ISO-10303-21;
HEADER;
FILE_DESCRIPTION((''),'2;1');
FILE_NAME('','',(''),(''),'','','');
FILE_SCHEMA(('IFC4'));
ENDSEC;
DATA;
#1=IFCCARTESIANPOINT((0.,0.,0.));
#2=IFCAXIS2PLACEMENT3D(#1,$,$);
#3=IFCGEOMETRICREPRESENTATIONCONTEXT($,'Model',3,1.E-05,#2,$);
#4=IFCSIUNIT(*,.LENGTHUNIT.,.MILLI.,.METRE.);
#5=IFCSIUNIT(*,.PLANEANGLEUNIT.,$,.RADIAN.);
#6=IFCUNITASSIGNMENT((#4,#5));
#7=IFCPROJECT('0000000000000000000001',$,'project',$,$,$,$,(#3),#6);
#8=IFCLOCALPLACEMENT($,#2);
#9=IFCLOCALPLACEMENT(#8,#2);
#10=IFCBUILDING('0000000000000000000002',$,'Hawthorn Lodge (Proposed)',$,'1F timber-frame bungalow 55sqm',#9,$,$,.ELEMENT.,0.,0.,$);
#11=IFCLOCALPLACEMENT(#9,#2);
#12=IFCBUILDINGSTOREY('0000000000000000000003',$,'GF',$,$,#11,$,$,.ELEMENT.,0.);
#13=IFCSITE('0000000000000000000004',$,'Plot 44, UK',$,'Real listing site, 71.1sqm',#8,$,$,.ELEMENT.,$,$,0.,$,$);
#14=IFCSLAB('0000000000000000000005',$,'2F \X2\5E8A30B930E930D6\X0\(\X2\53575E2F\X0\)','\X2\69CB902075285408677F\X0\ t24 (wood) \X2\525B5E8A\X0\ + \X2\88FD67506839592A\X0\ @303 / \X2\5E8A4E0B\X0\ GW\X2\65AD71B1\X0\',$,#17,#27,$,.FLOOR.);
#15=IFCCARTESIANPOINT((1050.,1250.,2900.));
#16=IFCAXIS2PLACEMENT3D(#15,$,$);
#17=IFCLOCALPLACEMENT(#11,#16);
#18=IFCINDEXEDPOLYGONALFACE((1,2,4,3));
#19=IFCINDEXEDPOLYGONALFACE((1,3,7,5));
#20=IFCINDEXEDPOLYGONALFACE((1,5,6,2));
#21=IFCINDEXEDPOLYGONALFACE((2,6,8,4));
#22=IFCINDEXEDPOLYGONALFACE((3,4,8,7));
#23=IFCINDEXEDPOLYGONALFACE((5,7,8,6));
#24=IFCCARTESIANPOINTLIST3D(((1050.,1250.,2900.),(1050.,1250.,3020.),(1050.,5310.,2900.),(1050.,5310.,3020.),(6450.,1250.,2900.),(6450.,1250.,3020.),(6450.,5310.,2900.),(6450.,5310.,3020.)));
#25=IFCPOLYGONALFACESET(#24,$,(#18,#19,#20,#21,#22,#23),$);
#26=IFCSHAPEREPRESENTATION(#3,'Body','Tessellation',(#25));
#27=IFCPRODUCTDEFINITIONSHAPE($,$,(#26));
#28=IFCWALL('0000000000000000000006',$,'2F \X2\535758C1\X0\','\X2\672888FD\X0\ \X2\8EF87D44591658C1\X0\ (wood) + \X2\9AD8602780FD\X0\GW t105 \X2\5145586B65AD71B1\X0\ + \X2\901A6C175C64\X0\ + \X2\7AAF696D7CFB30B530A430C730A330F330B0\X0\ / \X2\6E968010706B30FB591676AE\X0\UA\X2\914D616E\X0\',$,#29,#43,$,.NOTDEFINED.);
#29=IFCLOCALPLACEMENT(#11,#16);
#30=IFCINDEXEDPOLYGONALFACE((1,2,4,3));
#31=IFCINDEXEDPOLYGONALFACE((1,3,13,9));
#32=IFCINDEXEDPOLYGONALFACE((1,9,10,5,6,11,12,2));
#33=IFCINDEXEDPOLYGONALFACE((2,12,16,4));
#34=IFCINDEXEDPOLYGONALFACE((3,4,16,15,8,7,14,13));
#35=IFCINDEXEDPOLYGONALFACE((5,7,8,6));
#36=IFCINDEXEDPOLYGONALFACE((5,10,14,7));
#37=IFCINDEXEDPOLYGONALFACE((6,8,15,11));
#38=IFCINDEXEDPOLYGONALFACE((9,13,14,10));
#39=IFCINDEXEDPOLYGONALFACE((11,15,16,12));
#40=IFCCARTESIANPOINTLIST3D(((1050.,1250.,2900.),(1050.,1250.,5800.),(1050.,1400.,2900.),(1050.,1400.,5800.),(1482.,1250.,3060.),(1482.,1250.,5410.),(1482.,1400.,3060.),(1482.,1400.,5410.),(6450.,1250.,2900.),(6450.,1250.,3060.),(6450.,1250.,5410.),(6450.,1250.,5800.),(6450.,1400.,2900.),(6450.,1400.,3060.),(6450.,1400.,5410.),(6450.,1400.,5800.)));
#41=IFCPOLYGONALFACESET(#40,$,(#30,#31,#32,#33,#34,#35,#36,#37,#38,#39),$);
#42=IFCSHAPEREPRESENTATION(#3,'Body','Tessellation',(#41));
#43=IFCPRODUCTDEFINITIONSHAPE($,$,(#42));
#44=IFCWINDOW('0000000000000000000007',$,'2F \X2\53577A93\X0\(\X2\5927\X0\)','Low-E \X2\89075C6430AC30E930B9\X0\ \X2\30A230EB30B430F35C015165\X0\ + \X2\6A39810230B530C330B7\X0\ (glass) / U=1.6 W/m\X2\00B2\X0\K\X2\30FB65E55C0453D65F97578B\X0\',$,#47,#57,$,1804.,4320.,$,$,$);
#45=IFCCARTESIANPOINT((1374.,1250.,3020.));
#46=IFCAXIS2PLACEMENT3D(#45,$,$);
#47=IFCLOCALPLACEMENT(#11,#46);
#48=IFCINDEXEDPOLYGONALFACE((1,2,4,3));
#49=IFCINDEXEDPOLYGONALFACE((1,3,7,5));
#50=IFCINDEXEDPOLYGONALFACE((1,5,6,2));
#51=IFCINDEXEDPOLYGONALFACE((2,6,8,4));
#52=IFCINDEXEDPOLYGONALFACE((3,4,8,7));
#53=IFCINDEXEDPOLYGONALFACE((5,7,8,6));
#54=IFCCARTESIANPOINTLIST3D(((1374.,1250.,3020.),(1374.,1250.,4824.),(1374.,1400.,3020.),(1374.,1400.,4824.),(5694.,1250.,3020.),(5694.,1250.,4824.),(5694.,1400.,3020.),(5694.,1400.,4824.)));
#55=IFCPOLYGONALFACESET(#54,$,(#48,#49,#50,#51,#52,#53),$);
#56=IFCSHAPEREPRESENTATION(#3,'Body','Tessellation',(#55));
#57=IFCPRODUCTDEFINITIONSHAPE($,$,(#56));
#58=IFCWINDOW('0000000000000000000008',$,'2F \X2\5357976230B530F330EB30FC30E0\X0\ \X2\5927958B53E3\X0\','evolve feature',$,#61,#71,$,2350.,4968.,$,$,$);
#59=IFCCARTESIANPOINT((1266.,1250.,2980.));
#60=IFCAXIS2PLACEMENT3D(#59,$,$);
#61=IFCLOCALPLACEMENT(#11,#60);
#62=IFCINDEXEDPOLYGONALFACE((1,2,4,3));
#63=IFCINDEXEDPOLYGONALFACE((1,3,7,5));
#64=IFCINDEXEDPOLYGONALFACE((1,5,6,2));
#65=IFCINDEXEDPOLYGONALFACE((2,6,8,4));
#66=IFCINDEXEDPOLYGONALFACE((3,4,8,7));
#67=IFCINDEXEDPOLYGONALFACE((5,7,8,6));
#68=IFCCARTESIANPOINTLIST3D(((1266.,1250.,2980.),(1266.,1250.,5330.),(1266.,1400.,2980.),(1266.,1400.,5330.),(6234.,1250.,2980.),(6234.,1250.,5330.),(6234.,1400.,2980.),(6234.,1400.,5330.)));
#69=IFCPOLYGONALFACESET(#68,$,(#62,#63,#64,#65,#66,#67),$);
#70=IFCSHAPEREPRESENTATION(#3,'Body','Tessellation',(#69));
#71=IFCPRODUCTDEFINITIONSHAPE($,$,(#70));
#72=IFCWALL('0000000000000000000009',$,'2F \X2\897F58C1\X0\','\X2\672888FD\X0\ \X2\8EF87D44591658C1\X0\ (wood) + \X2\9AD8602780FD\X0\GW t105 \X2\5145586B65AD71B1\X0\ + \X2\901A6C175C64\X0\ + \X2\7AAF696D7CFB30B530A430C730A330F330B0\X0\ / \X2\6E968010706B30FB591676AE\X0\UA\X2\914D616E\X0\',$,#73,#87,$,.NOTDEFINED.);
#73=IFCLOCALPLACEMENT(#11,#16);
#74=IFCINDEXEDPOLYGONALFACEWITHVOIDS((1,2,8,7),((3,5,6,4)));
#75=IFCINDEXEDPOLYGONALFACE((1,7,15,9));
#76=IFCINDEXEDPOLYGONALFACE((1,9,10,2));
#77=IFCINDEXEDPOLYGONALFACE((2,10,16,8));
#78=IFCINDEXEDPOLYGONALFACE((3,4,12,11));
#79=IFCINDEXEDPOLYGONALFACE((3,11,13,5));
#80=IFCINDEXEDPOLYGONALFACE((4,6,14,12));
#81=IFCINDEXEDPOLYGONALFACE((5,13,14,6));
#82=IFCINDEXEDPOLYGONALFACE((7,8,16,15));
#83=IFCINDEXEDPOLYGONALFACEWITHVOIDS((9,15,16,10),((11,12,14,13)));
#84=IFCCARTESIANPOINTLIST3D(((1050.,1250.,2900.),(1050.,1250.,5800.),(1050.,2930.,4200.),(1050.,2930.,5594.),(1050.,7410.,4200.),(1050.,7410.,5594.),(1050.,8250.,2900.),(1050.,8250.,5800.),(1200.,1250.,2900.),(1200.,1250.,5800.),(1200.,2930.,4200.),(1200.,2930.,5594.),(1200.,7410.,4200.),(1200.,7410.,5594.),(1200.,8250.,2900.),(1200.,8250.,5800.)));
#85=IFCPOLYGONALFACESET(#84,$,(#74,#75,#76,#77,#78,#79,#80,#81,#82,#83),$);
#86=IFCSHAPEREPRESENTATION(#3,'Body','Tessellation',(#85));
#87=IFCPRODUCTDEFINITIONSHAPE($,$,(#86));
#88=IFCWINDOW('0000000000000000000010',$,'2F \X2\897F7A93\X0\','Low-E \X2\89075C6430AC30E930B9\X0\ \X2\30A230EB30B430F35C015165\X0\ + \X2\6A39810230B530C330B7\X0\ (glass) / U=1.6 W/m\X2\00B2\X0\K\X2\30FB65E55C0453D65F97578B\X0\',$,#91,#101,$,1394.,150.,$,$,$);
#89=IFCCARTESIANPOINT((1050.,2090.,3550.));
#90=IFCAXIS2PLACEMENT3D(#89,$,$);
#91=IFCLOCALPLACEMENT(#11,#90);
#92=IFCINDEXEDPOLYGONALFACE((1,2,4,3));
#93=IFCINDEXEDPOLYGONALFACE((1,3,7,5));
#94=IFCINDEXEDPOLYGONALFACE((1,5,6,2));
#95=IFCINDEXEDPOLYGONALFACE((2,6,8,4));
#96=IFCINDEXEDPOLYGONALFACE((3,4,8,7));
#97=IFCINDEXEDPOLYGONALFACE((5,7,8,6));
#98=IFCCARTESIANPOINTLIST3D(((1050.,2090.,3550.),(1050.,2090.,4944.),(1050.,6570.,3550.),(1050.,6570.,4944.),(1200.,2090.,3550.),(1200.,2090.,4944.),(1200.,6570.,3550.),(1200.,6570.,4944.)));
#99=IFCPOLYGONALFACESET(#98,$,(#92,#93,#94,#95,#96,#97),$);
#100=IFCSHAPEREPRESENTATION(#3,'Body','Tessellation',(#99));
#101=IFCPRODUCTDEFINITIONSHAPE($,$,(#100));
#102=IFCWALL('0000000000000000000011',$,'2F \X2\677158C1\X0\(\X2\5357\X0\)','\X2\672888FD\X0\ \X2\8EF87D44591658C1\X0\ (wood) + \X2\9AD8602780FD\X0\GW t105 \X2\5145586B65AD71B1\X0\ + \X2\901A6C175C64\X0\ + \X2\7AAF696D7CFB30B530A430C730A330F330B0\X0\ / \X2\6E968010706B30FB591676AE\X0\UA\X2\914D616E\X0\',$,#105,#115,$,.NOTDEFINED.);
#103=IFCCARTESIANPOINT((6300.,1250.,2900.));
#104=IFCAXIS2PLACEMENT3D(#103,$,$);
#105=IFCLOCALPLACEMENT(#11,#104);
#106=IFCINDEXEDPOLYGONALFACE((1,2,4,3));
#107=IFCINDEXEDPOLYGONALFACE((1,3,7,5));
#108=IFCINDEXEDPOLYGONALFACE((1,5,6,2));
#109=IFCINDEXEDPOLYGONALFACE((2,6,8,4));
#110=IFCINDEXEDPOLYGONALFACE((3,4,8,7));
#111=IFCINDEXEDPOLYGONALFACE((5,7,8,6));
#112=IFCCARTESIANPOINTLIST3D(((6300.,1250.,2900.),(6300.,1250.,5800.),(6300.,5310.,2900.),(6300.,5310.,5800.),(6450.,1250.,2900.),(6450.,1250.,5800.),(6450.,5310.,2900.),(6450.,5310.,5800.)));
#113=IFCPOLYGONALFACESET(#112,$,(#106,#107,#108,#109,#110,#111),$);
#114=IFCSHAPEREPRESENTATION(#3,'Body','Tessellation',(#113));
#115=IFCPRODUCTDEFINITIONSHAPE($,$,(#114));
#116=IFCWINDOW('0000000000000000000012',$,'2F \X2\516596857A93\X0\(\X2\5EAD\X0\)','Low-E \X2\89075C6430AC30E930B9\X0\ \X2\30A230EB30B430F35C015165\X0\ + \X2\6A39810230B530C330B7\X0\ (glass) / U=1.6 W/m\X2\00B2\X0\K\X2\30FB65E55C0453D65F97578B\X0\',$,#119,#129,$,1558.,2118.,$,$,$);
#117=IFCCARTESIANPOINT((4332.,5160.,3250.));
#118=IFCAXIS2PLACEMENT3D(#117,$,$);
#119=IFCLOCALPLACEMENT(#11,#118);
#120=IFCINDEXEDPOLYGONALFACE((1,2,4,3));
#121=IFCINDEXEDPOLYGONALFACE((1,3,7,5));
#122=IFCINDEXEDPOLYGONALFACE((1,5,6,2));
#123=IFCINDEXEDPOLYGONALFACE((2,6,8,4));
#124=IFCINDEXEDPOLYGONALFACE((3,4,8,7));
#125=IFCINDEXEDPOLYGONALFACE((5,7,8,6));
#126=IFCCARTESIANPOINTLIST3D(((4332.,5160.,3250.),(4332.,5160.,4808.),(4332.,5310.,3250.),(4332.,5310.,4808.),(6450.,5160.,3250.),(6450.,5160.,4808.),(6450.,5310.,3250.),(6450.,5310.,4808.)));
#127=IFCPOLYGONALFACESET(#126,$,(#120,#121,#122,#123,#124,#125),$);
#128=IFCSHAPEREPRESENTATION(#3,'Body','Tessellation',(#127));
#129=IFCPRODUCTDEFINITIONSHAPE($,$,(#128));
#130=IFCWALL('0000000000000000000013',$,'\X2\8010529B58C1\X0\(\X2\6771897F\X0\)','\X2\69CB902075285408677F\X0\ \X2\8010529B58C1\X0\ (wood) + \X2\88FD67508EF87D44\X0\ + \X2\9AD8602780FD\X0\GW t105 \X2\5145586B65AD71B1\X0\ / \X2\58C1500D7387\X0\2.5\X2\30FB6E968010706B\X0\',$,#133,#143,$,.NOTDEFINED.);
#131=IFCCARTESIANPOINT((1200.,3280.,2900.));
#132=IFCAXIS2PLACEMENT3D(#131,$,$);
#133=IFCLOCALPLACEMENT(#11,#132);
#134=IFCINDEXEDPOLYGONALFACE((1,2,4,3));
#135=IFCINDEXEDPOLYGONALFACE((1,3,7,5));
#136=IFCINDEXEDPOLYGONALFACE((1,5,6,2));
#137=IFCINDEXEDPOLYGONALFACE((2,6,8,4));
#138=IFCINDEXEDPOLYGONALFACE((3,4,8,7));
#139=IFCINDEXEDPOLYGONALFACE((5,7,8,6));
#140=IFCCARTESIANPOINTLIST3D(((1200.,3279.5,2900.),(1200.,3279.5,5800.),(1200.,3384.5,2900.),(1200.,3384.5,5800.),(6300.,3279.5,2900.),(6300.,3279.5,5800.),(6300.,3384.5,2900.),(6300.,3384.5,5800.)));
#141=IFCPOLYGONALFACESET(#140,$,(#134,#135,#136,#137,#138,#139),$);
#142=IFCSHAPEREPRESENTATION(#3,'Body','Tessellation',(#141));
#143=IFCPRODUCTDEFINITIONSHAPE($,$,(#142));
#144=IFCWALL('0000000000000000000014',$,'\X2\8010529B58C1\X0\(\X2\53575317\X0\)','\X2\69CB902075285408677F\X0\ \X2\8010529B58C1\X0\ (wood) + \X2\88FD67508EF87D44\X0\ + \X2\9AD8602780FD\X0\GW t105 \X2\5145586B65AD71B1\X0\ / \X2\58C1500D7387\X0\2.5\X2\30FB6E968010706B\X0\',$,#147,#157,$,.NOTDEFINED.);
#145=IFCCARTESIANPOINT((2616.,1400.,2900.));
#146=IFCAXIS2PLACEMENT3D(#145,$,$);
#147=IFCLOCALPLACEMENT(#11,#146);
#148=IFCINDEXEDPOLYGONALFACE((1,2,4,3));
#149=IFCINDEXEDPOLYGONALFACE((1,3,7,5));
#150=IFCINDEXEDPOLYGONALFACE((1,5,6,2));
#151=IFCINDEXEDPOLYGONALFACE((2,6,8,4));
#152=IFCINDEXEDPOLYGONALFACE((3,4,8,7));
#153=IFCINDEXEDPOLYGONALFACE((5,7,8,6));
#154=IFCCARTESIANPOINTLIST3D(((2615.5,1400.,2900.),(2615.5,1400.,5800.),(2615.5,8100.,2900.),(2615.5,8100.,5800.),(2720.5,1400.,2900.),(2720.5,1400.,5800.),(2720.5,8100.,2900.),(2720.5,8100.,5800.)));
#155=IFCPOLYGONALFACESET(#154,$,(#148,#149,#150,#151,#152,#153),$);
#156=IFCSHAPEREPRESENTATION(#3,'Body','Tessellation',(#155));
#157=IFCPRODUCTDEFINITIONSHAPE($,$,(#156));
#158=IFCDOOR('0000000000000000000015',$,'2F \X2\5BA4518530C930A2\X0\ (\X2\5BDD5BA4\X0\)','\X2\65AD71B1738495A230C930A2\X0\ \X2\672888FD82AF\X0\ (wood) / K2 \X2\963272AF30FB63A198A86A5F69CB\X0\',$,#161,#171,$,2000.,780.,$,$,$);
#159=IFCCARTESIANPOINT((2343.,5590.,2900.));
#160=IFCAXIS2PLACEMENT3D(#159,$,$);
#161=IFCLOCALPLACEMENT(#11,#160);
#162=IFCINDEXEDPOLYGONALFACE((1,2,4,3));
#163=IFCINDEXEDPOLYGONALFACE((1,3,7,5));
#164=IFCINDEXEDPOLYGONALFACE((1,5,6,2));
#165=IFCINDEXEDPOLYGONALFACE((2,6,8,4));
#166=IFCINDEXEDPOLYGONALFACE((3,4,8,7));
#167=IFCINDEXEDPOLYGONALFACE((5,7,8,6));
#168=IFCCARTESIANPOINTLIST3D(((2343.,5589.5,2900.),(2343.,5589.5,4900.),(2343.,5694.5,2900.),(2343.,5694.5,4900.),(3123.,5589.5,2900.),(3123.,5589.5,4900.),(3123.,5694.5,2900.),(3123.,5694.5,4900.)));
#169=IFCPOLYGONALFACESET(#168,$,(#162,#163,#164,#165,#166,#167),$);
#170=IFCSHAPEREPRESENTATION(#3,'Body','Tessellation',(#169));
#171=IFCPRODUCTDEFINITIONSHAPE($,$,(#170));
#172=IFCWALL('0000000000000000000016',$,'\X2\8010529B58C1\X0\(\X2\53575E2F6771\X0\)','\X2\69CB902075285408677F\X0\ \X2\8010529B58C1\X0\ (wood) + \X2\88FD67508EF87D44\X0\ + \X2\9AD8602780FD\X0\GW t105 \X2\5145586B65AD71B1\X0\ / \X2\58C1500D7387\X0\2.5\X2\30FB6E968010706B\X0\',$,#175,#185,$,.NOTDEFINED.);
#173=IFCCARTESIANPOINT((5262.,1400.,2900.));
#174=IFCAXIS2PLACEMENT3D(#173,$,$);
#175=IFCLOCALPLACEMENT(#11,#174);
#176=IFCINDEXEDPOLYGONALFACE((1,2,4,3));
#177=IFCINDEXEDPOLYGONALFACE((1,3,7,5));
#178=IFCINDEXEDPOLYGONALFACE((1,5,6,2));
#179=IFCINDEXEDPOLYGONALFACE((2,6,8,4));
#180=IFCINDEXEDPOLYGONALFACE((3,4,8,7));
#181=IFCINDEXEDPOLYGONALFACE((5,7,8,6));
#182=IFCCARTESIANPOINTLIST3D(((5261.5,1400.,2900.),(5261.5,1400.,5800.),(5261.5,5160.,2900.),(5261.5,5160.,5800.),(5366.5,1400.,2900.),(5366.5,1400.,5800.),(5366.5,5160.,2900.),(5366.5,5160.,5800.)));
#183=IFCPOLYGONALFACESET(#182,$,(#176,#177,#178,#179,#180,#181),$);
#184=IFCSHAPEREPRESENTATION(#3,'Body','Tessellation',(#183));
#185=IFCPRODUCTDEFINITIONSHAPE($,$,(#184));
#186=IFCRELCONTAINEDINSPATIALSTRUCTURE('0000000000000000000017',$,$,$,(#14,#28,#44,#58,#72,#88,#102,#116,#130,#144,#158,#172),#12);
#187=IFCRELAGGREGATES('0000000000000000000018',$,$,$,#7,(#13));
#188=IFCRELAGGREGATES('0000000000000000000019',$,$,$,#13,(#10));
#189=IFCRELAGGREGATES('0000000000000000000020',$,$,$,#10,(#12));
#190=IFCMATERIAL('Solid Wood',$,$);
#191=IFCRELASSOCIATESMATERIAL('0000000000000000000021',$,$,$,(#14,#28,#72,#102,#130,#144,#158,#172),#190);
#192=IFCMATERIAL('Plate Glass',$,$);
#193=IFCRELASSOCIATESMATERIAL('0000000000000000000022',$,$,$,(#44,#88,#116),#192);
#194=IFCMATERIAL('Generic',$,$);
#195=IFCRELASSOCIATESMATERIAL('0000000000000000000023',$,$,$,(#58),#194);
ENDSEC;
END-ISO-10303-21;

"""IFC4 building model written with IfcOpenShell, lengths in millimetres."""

from ifc_helpers import new_model, si_unit, frame, frame_2d, origin, place, context, project, spatial, rectangle, extrude, material, element, fill, save


model = new_model("IFC4")

# Units and contexts
model_context = context("Model", 3, precision=1e-05, world=origin())
ifc_project = project(units=[si_unit("LENGTHUNIT", "METRE", prefix="MILLI"), si_unit("PLANEANGLEUNIT", "RADIAN")], contexts=[model_context])

# Site, building, storey
site_placement = place(None, origin())
site = spatial("IfcSite", under=ifc_project, at=site_placement, Name="Plot 44, UK", ObjectType="Real listing site, 71.1sqm", CompositionType="ELEMENT", RefElevation=0.0)
building_placement = place(site_placement, origin())
building = spatial("IfcBuilding", under=site, at=building_placement, Name="Hawthorn Lodge (Proposed)", ObjectType="1F timber-frame bungalow 55sqm", CompositionType="ELEMENT", ElevationOfRefHeight=0.0, ElevationOfTerrain=0.0)
storey_placement = place(building_placement, origin())
storey = spatial("IfcBuildingStorey", under=building, at=storey_placement, Name="GF", CompositionType="ELEMENT", Elevation=0.0)

# Slab
ifc_material_1 = material(Name="Solid Wood")
slab_placement = place(storey_placement, frame((1050.0, 1250.0, 2900.0)))
element("IfcSlab", 1, at=slab_placement, inside=storey, material=ifc_material_1, Name="2F 床スラブ(南帯)", Description="構造用合板 t24 (wood) 剛床 + 製材根太 @303 / 床下 GW断熱", PredefinedType="FLOOR", context=model_context, shape_type="SweptSolid", body=[
    extrude(rectangle(XDim=5400.0, YDim=4060.0, at=frame_2d((2700.0, 2030.0))), frame((1050.0, 1250.0, 2900.0)), (0.0, 0.0, 1.0), 120.0),
])

# Wall, openings, windows
wall_1_placement = place(storey_placement, frame((1050.0, 1250.0, 2900.0)))
wall_1 = element("IfcWall", 2, at=wall_1_placement, inside=storey, material=ifc_material_1, Name="2F 南壁", Description="木製 軸組外壁 (wood) + 高性能GW t105 充填断熱 + 通気層 + 窯業系サイディング / 準耐火・外皮UA配慮", PredefinedType="NOTDEFINED", context=model_context, shape_type="SweptSolid", body=[
    extrude(rectangle(XDim=5400.0, YDim=150.0, at=frame_2d((2700.0, 75.0))), frame((1050.0, 1250.0, 2900.0)), (0.0, 0.0, 1.0), 2900.0),
])
opening_1_placement = place(storey_placement, frame((1374.0, 1250.0, 3020.0)))
opening_1 = element("IfcOpeningElement", 3, at=opening_1_placement, cuts=wall_1, PredefinedType="NOTDEFINED", context=model_context, shape_type="SweptSolid", body=[
    extrude(rectangle(XDim=4320.0, YDim=150.0, at=frame_2d((2160.0, 75.0))), frame((1374.0, 1250.0, 3020.0)), (0.0, 0.0, 1.0), 1804.0),
])
opening_2_placement = place(storey_placement, frame((1266.0, 1250.0, 2980.0)))
opening_2 = element("IfcOpeningElement", 4, at=opening_2_placement, cuts=wall_1, PredefinedType="NOTDEFINED", context=model_context, shape_type="SweptSolid", body=[
    extrude(rectangle(XDim=4968.0, YDim=150.0, at=frame_2d((2484.0, 75.0))), frame((1266.0, 1250.0, 2980.0)), (0.0, 0.0, 1.0), 2350.0),
])
ifc_material_2 = material(Name="Plate Glass")
window_1_placement = place(storey_placement, frame((1374.0, 1250.0, 3020.0)))
window_1 = element("IfcWindow", 5, at=window_1_placement, inside=storey, material=ifc_material_2, Name="2F 南窓(大)", Description="Low-E 複層ガラス アルゴン封入 + 樹脂サッシ (glass) / U=1.6 W/m²K・日射取得型", OverallHeight=1804.0, OverallWidth=4320.0, context=model_context, shape_type="SweptSolid", body=[
    extrude(rectangle(XDim=4320.0, YDim=150.0, at=frame_2d((2160.0, 75.0))), frame((1374.0, 1250.0, 3020.0)), (0.0, 0.0, 1.0), 1804.0),
])
fill(opening_1, window_1)
ifc_material_3 = material(Name="Generic")
window_2_placement = place(storey_placement, frame((1266.0, 1250.0, 2980.0)))
window_2 = element("IfcWindow", 6, at=window_2_placement, inside=storey, material=ifc_material_3, Name="2F 南面サンルーム 大開口", Description="evolve feature", OverallHeight=2350.0, OverallWidth=4968.0, context=model_context, shape_type="SweptSolid", body=[
    extrude(rectangle(XDim=4968.0, YDim=150.0, at=frame_2d((2484.0, 75.0))), frame((1266.0, 1250.0, 2980.0)), (0.0, 0.0, 1.0), 2350.0),
])
fill(opening_2, window_2)

# Walls, openings, windows
wall_2_placement = place(storey_placement, frame((1050.0, 1250.0, 2900.0)))
wall_2 = element("IfcWall", 7, at=wall_2_placement, inside=storey, material=ifc_material_1, Name="2F 西壁", Description="木製 軸組外壁 (wood) + 高性能GW t105 充填断熱 + 通気層 + 窯業系サイディング / 準耐火・外皮UA配慮", PredefinedType="NOTDEFINED", context=model_context, shape_type="SweptSolid", body=[
    extrude(rectangle(XDim=150.0, YDim=7000.0, at=frame_2d((75.0, 3500.0))), frame((1050.0, 1250.0, 2900.0)), (0.0, 0.0, 1.0), 2900.0),
])
opening_3_placement = place(storey_placement, frame((1050.0, 2090.0, 3550.0)))
opening_3 = element("IfcOpeningElement", 8, at=opening_3_placement, cuts=wall_2, PredefinedType="NOTDEFINED", context=model_context, shape_type="SweptSolid", body=[
    extrude(rectangle(XDim=150.0, YDim=4480.0, at=frame_2d((75.0, 2240.0))), frame((1050.0, 2090.0, 3550.0)), (0.0, 0.0, 1.0), 1394.0),
])
window_3_placement = place(storey_placement, frame((1050.0, 2090.0, 3550.0)))
window_3 = element("IfcWindow", 9, at=window_3_placement, inside=storey, material=ifc_material_2, Name="2F 西窓", Description="Low-E 複層ガラス アルゴン封入 + 樹脂サッシ (glass) / U=1.6 W/m²K・日射取得型", OverallHeight=1394.0, OverallWidth=150.0, context=model_context, shape_type="SweptSolid", body=[
    extrude(rectangle(XDim=150.0, YDim=4480.0, at=frame_2d((75.0, 2240.0))), frame((1050.0, 2090.0, 3550.0)), (0.0, 0.0, 1.0), 1394.0),
])
fill(opening_3, window_3)
wall_3_placement = place(storey_placement, frame((6300.0, 1250.0, 2900.0)))
wall_3 = element("IfcWall", 10, at=wall_3_placement, inside=storey, material=ifc_material_1, Name="2F 東壁(南)", Description="木製 軸組外壁 (wood) + 高性能GW t105 充填断熱 + 通気層 + 窯業系サイディング / 準耐火・外皮UA配慮", PredefinedType="NOTDEFINED", context=model_context, shape_type="SweptSolid", body=[
    extrude(rectangle(XDim=150.0, YDim=4060.0, at=frame_2d((75.0, 2030.0))), frame((6300.0, 1250.0, 2900.0)), (0.0, 0.0, 1.0), 2900.0),
])
opening_4_placement = place(storey_placement, frame((4332.0, 5160.0, 3250.0)))
opening_4 = element("IfcOpeningElement", 11, at=opening_4_placement, cuts=wall_3, PredefinedType="NOTDEFINED", context=model_context, shape_type="SweptSolid", body=[
    extrude(rectangle(XDim=2118.0, YDim=150.0, at=frame_2d((1059.0, 75.0))), frame((4332.0, 5160.0, 3250.0)), (0.0, 0.0, 1.0), 1558.0),
])
window_4_placement = place(storey_placement, frame((4332.0, 5160.0, 3250.0)))
window_4 = element("IfcWindow", 12, at=window_4_placement, inside=storey, material=ifc_material_2, Name="2F 入隅窓(庭)", Description="Low-E 複層ガラス アルゴン封入 + 樹脂サッシ (glass) / U=1.6 W/m²K・日射取得型", OverallHeight=1558.0, OverallWidth=2118.0, context=model_context, shape_type="SweptSolid", body=[
    extrude(rectangle(XDim=2118.0, YDim=150.0, at=frame_2d((1059.0, 75.0))), frame((4332.0, 5160.0, 3250.0)), (0.0, 0.0, 1.0), 1558.0),
])
fill(opening_4, window_4)

# Wall
wall_4_placement = place(storey_placement, frame((1200.0, 3280.0, 2900.0)))
element("IfcWall", 13, at=wall_4_placement, inside=storey, material=ifc_material_1, Name="耐力壁(東西)", Description="構造用合板 耐力壁 (wood) + 製材軸組 + 高性能GW t105 充填断熱 / 壁倍率2.5・準耐火", PredefinedType="NOTDEFINED", context=model_context, shape_type="SweptSolid", body=[
    extrude(rectangle(XDim=5100.0, YDim=105.0, at=frame_2d((2550.0, 52.0))), frame((1200.0, 3280.0, 2900.0)), (0.0, 0.0, 1.0), 2900.0),
])

# Wall, opening, door
wall_5_placement = place(storey_placement, frame((2616.0, 1400.0, 2900.0)))
wall_5 = element("IfcWall", 14, at=wall_5_placement, inside=storey, material=ifc_material_1, Name="耐力壁(南北)", Description="構造用合板 耐力壁 (wood) + 製材軸組 + 高性能GW t105 充填断熱 / 壁倍率2.5・準耐火", PredefinedType="NOTDEFINED", context=model_context, shape_type="SweptSolid", body=[
    extrude(rectangle(XDim=105.0, YDim=6700.0, at=frame_2d((52.0, 3350.0))), frame((2616.0, 1400.0, 2900.0)), (0.0, 0.0, 1.0), 2900.0),
])
opening_5_placement = place(storey_placement, frame((2343.0, 5590.0, 2900.0)))
opening_5 = element("IfcOpeningElement", 15, at=opening_5_placement, cuts=wall_5, PredefinedType="NOTDEFINED", context=model_context, shape_type="SweptSolid", body=[
    extrude(rectangle(XDim=780.0, YDim=105.0, at=frame_2d((390.0, 52.0))), frame((2343.0, 5590.0, 2900.0)), (0.0, 0.0, 1.0), 2000.0),
])
door_placement = place(storey_placement, frame((2343.0, 5590.0, 2900.0)))
door = element("IfcDoor", 16, at=door_placement, inside=storey, material=ifc_material_1, Name="2F 室内ドア (寝室)", Description="断熱玄関ドア 木製芯 (wood) / K2 防犯・採風機構", OverallHeight=2000.0, OverallWidth=780.0, context=model_context, shape_type="SweptSolid", body=[
    extrude(rectangle(XDim=780.0, YDim=105.0, at=frame_2d((390.0, 52.0))), frame((2343.0, 5590.0, 2900.0)), (0.0, 0.0, 1.0), 2000.0),
])
fill(opening_5, door)

# Wall
wall_6_placement = place(storey_placement, frame((5262.0, 1400.0, 2900.0)))
element("IfcWall", 17, at=wall_6_placement, inside=storey, material=ifc_material_1, Name="耐力壁(南帯東)", Description="構造用合板 耐力壁 (wood) + 製材軸組 + 高性能GW t105 充填断熱 / 壁倍率2.5・準耐火", PredefinedType="NOTDEFINED", context=model_context, shape_type="SweptSolid", body=[
    extrude(rectangle(XDim=105.0, YDim=3760.0, at=frame_2d((52.0, 1880.0))), frame((5262.0, 1400.0, 2900.0)), (0.0, 0.0, 1.0), 2900.0),
])

save(model, "model.ifc")
